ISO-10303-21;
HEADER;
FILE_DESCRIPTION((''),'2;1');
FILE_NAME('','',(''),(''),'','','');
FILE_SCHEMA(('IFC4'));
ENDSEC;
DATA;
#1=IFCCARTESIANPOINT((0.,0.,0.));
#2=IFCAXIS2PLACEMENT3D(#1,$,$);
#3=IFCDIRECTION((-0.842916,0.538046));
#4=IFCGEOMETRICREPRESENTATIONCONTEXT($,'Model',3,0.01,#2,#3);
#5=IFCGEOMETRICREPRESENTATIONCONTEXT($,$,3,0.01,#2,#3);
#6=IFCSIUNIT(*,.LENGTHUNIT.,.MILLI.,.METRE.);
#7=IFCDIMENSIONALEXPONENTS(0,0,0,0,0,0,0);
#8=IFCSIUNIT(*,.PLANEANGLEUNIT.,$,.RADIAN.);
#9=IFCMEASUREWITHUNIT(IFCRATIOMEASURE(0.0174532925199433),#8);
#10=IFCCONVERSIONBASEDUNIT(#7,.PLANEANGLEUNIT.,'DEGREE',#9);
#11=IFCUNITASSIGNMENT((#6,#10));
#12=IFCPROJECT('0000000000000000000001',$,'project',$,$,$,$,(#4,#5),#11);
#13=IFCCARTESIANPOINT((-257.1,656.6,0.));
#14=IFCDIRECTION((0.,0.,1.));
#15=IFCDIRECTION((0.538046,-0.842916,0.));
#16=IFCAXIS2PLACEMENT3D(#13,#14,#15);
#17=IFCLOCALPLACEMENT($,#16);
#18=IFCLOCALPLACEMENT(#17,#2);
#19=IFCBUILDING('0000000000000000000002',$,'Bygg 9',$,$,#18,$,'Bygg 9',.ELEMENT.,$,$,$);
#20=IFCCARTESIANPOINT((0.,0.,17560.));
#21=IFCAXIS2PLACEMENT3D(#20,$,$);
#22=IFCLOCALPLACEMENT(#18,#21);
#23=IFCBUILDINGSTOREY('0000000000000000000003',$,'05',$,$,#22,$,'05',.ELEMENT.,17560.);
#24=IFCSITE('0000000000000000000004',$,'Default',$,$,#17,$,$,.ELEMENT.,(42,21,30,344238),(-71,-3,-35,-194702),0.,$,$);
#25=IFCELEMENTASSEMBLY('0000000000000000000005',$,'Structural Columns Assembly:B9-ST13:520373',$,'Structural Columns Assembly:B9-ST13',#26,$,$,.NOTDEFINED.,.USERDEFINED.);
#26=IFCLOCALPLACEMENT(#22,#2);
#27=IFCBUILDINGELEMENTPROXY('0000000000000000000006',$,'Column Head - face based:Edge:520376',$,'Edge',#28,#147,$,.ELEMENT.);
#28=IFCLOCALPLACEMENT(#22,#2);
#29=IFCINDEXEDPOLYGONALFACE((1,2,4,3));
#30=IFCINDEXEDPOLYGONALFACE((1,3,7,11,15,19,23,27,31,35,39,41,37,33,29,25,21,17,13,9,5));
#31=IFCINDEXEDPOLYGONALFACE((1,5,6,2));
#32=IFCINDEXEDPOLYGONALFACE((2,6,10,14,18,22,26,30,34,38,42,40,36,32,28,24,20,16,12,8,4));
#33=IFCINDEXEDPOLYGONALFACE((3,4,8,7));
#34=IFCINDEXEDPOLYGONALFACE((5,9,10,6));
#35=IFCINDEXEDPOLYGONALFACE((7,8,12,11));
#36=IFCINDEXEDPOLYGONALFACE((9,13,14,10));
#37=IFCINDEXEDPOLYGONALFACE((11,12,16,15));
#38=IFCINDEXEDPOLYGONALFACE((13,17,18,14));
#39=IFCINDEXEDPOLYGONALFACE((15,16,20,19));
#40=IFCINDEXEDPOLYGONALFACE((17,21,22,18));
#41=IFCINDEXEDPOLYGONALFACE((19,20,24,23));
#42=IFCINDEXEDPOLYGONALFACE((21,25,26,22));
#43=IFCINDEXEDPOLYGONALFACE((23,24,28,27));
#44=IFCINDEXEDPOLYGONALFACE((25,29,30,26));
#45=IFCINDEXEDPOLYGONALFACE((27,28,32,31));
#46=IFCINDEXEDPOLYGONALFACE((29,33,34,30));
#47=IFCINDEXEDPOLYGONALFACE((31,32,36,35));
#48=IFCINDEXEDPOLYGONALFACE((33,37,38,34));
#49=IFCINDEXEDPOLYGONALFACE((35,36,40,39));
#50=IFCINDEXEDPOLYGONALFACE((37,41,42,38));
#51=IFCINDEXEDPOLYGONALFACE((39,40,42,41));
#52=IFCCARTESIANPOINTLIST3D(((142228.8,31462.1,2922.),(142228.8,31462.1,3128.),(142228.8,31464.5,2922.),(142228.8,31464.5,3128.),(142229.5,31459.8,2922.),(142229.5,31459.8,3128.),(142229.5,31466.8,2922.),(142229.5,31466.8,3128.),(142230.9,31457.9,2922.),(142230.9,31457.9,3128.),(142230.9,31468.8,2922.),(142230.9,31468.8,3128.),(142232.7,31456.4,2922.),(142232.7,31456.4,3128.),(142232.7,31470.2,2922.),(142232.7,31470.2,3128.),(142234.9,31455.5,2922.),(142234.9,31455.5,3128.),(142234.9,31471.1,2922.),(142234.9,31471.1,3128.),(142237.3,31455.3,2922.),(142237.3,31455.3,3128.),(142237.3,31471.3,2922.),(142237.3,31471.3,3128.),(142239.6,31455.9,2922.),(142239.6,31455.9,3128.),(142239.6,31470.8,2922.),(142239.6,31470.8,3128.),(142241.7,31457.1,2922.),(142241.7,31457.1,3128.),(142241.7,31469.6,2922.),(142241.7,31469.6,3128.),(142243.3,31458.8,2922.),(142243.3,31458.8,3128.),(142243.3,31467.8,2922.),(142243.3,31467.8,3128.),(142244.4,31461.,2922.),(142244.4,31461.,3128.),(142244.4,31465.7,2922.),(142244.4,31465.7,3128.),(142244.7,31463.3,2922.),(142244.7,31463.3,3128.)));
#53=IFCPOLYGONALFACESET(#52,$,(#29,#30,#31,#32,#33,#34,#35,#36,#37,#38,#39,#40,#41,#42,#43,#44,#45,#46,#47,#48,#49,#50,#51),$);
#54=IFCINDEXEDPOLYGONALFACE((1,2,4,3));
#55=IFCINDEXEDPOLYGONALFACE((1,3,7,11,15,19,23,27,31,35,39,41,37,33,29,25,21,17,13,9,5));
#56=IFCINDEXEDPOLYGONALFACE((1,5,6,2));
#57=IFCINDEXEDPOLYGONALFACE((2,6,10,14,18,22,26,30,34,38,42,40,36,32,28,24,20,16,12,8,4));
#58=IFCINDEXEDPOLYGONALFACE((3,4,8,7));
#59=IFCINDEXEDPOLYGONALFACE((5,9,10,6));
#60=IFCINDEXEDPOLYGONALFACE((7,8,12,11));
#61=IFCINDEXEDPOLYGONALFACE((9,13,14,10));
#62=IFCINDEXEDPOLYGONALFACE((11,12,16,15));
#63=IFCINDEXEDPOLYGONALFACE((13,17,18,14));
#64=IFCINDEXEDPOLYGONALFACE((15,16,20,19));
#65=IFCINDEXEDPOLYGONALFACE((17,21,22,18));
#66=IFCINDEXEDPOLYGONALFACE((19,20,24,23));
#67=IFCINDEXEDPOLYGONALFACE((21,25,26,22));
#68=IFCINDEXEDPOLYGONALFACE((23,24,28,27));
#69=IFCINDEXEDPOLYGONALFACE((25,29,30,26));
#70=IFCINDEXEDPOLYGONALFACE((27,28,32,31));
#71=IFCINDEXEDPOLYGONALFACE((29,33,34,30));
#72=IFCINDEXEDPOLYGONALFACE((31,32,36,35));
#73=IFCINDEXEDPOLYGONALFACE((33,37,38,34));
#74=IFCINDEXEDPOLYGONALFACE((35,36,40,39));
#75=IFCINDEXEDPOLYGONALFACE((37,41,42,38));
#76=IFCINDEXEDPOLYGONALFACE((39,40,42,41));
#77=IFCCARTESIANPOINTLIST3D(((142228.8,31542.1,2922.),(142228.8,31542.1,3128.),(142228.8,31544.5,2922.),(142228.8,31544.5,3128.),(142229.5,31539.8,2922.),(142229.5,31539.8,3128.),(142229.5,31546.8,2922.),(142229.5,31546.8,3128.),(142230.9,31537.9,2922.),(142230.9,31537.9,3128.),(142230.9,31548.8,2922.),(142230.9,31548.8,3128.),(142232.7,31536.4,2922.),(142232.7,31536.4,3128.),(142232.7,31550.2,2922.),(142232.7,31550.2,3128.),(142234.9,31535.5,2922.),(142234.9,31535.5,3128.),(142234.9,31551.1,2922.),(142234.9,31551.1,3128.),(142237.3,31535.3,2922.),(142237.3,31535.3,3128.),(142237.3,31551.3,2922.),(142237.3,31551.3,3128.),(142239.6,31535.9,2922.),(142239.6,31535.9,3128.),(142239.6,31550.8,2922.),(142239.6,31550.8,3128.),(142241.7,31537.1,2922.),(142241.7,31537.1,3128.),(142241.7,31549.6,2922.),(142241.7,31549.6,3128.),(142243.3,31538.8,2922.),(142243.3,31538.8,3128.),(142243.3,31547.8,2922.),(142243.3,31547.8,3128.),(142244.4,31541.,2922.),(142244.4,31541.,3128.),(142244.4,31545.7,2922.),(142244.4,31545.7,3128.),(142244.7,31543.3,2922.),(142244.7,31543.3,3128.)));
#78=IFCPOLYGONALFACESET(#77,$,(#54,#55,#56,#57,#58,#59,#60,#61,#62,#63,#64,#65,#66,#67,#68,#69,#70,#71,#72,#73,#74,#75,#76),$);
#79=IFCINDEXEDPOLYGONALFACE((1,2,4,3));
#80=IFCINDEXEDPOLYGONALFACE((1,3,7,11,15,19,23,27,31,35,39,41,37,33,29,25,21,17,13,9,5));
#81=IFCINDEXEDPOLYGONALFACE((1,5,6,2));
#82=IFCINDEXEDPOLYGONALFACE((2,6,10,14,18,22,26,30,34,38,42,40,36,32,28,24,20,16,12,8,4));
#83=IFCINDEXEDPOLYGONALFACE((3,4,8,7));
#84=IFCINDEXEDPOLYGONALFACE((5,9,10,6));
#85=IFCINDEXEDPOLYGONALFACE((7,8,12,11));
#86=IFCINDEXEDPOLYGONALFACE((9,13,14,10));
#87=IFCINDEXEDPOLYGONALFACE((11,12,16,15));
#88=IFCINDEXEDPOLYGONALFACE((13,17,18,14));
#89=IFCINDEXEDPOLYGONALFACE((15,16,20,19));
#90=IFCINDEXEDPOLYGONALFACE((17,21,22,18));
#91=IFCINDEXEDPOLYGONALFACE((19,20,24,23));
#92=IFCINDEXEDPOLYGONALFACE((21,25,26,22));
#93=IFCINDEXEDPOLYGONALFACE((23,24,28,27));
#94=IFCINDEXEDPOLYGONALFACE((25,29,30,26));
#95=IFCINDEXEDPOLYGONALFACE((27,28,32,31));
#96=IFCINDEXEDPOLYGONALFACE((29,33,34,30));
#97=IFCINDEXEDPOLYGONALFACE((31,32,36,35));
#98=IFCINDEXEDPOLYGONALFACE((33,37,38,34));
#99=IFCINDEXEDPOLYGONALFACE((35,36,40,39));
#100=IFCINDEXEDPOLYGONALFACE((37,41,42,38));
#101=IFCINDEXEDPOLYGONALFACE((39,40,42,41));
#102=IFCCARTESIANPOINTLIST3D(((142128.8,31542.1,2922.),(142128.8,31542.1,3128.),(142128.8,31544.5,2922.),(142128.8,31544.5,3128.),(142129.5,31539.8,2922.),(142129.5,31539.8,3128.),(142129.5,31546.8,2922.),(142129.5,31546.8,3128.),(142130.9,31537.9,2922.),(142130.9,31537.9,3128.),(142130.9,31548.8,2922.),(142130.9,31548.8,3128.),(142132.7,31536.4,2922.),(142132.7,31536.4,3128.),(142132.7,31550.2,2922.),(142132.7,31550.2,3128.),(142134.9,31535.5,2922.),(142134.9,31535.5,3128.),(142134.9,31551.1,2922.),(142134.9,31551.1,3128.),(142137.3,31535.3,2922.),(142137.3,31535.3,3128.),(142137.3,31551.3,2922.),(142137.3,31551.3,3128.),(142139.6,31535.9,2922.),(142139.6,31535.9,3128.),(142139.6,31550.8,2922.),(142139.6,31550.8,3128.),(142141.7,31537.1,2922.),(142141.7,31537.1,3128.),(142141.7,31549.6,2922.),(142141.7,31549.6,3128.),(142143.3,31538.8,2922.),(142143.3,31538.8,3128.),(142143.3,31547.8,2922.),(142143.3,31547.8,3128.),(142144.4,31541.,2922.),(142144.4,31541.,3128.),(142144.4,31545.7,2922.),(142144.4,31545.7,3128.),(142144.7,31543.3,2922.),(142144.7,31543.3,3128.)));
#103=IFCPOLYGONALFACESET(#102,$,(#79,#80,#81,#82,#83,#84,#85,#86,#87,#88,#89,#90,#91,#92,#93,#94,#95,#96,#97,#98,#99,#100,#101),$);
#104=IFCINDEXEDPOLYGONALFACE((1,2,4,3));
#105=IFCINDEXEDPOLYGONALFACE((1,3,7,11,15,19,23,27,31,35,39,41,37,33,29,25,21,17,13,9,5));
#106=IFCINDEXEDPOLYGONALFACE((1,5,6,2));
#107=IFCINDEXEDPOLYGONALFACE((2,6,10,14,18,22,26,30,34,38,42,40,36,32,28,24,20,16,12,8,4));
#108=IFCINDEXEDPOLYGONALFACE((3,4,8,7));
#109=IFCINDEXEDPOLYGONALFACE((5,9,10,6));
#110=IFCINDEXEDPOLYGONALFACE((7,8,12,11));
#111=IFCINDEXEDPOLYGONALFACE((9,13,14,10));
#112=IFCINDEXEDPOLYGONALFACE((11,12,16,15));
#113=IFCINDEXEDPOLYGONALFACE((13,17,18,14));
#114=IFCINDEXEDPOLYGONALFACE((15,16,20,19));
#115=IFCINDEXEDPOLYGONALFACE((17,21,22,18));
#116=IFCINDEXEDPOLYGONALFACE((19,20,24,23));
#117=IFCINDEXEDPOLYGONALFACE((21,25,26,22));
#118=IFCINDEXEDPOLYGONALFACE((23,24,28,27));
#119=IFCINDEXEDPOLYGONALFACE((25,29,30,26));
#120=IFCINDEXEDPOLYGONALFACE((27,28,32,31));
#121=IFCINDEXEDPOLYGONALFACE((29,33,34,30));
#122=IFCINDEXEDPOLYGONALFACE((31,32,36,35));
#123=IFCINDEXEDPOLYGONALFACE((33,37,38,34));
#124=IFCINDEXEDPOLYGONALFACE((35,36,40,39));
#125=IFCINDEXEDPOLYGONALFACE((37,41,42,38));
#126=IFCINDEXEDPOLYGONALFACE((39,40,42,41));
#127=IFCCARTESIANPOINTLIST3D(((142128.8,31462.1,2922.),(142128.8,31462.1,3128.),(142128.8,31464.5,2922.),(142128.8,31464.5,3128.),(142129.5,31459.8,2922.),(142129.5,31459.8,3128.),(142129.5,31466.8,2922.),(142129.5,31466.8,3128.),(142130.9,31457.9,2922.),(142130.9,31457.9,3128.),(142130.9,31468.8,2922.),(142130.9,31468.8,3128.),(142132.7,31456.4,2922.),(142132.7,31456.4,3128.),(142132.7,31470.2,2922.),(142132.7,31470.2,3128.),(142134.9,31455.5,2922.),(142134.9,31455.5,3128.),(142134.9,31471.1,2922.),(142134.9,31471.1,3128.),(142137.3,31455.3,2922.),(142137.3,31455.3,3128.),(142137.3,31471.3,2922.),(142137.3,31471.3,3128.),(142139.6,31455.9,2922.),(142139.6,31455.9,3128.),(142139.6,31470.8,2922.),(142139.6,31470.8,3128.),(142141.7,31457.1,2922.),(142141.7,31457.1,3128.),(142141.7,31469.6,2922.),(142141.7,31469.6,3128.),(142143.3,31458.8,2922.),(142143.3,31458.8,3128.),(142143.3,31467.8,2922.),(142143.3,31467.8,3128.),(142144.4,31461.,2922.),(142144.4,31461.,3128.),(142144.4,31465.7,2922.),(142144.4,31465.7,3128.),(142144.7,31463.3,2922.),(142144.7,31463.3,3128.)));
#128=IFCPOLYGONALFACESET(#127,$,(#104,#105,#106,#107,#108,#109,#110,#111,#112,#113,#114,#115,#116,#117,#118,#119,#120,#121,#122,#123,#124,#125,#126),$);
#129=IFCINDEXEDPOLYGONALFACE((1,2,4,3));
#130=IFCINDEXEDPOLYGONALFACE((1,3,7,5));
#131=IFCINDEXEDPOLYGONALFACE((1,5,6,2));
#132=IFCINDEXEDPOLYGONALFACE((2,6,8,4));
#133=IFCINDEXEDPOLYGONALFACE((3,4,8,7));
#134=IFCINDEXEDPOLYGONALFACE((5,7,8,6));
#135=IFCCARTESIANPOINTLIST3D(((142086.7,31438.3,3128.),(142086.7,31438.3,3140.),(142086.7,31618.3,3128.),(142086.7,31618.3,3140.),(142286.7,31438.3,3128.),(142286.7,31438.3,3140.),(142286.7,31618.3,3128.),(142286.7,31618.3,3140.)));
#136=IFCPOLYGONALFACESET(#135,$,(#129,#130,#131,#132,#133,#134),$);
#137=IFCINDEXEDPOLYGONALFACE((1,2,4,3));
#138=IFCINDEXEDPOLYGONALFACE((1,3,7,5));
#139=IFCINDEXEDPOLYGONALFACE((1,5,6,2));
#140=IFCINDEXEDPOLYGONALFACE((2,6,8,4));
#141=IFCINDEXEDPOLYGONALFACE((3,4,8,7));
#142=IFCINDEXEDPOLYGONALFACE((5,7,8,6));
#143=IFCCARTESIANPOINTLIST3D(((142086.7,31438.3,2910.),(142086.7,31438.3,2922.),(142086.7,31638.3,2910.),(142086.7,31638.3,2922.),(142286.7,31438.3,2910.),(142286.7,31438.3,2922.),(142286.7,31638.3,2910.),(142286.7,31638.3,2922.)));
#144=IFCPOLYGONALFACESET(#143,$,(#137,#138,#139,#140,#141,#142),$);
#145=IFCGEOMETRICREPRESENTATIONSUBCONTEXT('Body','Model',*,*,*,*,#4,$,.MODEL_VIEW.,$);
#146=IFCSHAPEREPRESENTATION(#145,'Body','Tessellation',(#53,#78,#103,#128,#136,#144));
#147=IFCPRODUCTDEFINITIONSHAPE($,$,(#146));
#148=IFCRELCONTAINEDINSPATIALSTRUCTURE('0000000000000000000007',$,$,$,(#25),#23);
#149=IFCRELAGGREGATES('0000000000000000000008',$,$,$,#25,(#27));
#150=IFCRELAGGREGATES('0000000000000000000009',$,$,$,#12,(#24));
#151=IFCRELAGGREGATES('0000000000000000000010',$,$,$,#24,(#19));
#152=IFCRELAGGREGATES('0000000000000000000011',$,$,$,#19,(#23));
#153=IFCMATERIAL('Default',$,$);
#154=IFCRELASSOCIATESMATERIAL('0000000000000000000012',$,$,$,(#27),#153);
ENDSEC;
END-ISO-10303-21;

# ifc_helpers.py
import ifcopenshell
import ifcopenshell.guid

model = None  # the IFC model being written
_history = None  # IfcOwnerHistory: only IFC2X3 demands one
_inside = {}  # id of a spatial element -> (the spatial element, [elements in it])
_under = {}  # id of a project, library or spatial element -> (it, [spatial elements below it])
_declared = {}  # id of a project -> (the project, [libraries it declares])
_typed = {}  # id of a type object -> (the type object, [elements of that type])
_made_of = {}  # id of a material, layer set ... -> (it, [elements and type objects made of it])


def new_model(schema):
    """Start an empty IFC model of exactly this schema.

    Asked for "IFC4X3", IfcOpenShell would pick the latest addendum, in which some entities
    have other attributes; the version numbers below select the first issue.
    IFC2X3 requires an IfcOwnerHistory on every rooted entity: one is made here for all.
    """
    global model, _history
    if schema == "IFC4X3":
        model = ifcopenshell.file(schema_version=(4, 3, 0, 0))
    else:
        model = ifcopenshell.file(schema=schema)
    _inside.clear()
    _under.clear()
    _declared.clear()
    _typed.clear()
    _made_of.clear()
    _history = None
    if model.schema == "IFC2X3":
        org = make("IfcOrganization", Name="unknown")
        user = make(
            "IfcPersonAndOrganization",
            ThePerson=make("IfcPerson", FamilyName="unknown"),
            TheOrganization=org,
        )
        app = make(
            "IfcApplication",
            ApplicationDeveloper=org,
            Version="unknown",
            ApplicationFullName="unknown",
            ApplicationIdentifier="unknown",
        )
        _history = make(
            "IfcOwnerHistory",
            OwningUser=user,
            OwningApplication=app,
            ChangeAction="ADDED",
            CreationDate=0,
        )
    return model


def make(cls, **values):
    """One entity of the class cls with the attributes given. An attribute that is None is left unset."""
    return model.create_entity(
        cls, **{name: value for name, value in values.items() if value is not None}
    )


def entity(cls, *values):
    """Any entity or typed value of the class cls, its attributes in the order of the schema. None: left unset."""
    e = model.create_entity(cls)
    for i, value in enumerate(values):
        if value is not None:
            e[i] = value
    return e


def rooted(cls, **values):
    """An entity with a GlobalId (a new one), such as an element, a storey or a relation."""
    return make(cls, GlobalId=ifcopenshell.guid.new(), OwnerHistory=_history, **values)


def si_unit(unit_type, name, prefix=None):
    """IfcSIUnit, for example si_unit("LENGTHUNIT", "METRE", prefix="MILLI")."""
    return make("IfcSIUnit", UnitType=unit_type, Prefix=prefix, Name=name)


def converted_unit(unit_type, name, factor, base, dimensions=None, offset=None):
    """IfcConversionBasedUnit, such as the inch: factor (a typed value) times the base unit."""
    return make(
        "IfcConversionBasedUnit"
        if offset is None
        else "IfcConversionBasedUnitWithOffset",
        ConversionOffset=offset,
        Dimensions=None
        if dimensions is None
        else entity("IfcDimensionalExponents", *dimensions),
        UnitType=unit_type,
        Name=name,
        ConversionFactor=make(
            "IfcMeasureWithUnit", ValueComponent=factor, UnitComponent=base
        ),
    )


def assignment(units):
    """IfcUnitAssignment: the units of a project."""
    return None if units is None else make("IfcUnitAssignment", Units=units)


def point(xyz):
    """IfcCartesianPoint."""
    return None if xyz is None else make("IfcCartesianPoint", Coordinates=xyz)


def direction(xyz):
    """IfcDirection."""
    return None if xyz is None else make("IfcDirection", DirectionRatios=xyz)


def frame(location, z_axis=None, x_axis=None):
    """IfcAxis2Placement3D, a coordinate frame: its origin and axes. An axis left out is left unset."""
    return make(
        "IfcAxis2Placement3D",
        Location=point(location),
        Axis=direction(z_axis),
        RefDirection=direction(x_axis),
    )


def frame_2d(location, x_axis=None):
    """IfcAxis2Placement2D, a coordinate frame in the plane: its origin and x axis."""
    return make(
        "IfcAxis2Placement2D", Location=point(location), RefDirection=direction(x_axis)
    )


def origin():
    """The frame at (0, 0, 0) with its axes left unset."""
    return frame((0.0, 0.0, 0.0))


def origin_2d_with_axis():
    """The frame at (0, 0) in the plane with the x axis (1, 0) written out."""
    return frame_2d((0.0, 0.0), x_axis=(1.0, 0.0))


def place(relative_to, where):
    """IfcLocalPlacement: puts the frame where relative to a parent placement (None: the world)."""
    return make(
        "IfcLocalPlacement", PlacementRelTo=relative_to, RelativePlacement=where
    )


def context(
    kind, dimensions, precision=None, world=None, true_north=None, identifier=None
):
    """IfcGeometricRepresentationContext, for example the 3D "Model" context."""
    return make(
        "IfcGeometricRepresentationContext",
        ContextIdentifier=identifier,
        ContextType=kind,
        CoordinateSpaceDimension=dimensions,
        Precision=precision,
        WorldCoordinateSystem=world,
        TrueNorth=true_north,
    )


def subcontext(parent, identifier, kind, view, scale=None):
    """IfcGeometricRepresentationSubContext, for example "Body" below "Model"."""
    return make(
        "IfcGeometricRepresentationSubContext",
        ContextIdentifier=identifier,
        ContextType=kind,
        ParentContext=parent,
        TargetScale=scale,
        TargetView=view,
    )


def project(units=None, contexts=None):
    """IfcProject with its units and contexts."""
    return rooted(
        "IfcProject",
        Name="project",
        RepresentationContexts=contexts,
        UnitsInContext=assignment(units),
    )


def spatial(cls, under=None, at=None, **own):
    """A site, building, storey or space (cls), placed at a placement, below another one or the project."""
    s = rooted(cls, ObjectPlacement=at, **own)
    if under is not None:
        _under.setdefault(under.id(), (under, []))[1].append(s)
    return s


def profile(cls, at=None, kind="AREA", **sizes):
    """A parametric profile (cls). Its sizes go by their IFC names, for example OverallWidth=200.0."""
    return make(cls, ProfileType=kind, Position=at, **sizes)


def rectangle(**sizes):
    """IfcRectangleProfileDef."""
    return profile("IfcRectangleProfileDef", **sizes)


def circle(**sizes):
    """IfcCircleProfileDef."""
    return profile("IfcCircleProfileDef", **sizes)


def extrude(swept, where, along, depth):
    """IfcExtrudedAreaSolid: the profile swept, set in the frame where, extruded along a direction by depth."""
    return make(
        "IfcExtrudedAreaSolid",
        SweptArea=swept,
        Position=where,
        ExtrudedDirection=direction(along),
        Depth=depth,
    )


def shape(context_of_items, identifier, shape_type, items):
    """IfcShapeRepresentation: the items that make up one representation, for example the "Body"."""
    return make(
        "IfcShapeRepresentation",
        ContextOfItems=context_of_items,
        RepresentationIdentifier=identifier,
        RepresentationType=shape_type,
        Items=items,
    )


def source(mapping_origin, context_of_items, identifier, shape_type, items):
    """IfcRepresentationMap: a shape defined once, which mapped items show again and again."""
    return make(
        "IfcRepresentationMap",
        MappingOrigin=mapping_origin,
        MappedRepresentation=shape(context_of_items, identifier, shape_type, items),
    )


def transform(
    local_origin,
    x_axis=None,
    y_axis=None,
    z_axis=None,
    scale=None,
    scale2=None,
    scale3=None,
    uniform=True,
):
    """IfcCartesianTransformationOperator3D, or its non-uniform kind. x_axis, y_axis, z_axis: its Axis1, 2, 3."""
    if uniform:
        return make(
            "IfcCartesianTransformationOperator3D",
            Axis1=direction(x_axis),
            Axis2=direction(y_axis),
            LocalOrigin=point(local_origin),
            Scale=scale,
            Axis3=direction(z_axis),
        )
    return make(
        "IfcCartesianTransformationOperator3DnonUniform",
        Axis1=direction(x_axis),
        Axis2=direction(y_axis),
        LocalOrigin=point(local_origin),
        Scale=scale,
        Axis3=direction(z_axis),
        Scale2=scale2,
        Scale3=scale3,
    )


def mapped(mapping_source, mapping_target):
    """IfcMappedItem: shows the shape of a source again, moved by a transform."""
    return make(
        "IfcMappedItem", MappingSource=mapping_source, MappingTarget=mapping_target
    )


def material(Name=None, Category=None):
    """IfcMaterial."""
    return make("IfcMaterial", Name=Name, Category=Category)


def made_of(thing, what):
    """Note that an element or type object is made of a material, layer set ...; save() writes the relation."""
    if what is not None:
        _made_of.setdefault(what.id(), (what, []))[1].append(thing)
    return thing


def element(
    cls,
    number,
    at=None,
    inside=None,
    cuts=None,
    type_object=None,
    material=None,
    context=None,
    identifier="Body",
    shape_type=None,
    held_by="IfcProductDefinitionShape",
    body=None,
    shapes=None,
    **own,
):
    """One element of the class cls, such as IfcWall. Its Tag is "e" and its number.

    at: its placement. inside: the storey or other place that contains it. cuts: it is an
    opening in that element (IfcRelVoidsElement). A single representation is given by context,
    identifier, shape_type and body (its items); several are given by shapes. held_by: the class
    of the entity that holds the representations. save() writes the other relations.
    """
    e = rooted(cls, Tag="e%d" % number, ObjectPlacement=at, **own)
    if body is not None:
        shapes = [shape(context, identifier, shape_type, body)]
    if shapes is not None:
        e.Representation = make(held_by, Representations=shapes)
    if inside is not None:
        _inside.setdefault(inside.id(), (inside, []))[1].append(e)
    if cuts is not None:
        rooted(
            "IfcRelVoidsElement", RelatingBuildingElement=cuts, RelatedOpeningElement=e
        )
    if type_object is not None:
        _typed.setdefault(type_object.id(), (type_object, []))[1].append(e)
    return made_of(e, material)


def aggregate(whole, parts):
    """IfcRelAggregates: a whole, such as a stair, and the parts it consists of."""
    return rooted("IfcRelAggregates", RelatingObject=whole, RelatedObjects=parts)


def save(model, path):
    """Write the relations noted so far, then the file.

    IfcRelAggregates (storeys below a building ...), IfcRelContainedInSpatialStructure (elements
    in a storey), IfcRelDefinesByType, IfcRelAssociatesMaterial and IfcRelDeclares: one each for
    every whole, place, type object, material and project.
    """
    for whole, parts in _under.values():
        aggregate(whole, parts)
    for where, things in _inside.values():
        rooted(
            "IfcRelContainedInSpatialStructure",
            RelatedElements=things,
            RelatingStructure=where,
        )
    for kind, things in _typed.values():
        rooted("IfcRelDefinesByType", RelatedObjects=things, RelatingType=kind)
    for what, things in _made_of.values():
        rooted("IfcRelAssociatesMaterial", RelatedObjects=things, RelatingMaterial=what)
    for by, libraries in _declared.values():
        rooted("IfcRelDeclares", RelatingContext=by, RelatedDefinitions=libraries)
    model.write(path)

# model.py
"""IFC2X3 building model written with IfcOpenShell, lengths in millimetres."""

from ifc_helpers import new_model, entity, si_unit, converted_unit, direction, frame, frame_2d, origin, origin_2d_with_axis, place, context, subcontext, project, spatial, rectangle, circle, extrude, source, transform, mapped, material, element, aggregate, save


model = new_model("IFC2X3")

# Units and contexts
model_context = context("Model", 3, precision=0.01, world=origin(), true_north=direction((-0.842916, 0.538046)))
context_of_model = context(None, 3, precision=0.01, world=origin(), true_north=direction((-0.842916, 0.538046)))
body_context = subcontext(model_context, "Body", "Model", "MODEL_VIEW")
ifc_project = project(units=[si_unit("LENGTHUNIT", "METRE", prefix="MILLI"), converted_unit("PLANEANGLEUNIT", "DEGREE", entity("IfcRatioMeasure", 0.0174532925199433), si_unit("PLANEANGLEUNIT", "RADIAN"), dimensions=[0, 0, 0, 0, 0, 0, 0])], contexts=[model_context, context_of_model])

# Site, building, storey
site_placement = place(None, frame((-257.1, 656.6, 0.0), z_axis=(0.0, 0.0, 1.0), x_axis=(0.538046, -0.842916, 0.0)))
site = spatial("IfcSite", under=ifc_project, at=site_placement, Name="Default", CompositionType="ELEMENT", RefLatitude=(42, 21, 30, 344238), RefLongitude=(-71, -3, -35, -194702), RefElevation=0.0)
building_placement = place(site_placement, origin())
building = spatial("IfcBuilding", under=site, at=building_placement, Name="Bygg 9", LongName="Bygg 9", CompositionType="ELEMENT")
storey_placement = place(building_placement, frame((0.0, 0.0, 17560.0)))
storey = spatial("IfcBuildingStorey", under=building, at=storey_placement, Name="05", LongName="05", CompositionType="ELEMENT", Elevation=17560.0)

# Shared definitions
ifc_material_1 = material(Name="Default")

# Element assembly, building element proxy
shared_shape_1 = source(origin(), body_context, "Body", "SweptSolid", [
    extrude(circle(Radius=8.0, at=frame_2d((0.0, 0.0), x_axis=(1.0, 0.0))), frame((50.0, -135.0, 12.0)), (0.0, 0.0, 1.0), 206.0),
    extrude(circle(Radius=8.0, at=frame_2d((0.0, 0.0), x_axis=(1.0, 0.0))), frame((50.0, -55.0, 12.0)), (0.0, 0.0, 1.0), 206.0),
    extrude(circle(Radius=8.0, at=frame_2d((0.0, 0.0), x_axis=(1.0, 0.0))), frame((-50.0, -55.0, 12.0)), (0.0, 0.0, 1.0), 206.0),
    extrude(circle(Radius=8.0, at=frame_2d((0.0, 0.0), x_axis=(1.0, 0.0))), frame((-50.0, -135.0, 12.0)), (0.0, 0.0, 1.0), 206.0),
    extrude(rectangle(XDim=200.0, YDim=180.0, at=origin_2d_with_axis()), frame((0.0, -70.0, 218.0), z_axis=(0.0, 0.0, 1.0), x_axis=(-1.0, 0.0, 0.0)), (0.0, 0.0, 1.0), 12.0),
    extrude(rectangle(XDim=200.0, YDim=200.0, at=origin_2d_with_axis()), frame((0.0, -60.0, 0.0), z_axis=(0.0, 0.0, 1.0), x_axis=(0.0, 1.0, 0.0)), (0.0, 0.0, 1.0), 12.0),
])
assembly_1_placement = place(storey_placement, origin())
assembly_1 = element("IfcElementAssembly", 1, at=assembly_1_placement, inside=storey, Name="Structural Columns Assembly:B9-ST13:520373", ObjectType="Structural Columns Assembly:B9-ST13", AssemblyPlace="NOTDEFINED", PredefinedType="USERDEFINED")
proxy_1_placement = place(assembly_1_placement, frame((142186.7, 31598.3, 2910.0)))
proxy_1 = element("IfcBuildingElementProxy", 2, at=proxy_1_placement, material=ifc_material_1, Name="Column Head - face based:Edge:520376", ObjectType="Edge", CompositionType="ELEMENT", context=body_context, shape_type="MappedRepresentation", body=[
    mapped(shared_shape_1, transform((0.0, 0.0, 0.0), scale=1.0)),
])
aggregate(assembly_1, [proxy_1])

save(model, "model.ifc")
